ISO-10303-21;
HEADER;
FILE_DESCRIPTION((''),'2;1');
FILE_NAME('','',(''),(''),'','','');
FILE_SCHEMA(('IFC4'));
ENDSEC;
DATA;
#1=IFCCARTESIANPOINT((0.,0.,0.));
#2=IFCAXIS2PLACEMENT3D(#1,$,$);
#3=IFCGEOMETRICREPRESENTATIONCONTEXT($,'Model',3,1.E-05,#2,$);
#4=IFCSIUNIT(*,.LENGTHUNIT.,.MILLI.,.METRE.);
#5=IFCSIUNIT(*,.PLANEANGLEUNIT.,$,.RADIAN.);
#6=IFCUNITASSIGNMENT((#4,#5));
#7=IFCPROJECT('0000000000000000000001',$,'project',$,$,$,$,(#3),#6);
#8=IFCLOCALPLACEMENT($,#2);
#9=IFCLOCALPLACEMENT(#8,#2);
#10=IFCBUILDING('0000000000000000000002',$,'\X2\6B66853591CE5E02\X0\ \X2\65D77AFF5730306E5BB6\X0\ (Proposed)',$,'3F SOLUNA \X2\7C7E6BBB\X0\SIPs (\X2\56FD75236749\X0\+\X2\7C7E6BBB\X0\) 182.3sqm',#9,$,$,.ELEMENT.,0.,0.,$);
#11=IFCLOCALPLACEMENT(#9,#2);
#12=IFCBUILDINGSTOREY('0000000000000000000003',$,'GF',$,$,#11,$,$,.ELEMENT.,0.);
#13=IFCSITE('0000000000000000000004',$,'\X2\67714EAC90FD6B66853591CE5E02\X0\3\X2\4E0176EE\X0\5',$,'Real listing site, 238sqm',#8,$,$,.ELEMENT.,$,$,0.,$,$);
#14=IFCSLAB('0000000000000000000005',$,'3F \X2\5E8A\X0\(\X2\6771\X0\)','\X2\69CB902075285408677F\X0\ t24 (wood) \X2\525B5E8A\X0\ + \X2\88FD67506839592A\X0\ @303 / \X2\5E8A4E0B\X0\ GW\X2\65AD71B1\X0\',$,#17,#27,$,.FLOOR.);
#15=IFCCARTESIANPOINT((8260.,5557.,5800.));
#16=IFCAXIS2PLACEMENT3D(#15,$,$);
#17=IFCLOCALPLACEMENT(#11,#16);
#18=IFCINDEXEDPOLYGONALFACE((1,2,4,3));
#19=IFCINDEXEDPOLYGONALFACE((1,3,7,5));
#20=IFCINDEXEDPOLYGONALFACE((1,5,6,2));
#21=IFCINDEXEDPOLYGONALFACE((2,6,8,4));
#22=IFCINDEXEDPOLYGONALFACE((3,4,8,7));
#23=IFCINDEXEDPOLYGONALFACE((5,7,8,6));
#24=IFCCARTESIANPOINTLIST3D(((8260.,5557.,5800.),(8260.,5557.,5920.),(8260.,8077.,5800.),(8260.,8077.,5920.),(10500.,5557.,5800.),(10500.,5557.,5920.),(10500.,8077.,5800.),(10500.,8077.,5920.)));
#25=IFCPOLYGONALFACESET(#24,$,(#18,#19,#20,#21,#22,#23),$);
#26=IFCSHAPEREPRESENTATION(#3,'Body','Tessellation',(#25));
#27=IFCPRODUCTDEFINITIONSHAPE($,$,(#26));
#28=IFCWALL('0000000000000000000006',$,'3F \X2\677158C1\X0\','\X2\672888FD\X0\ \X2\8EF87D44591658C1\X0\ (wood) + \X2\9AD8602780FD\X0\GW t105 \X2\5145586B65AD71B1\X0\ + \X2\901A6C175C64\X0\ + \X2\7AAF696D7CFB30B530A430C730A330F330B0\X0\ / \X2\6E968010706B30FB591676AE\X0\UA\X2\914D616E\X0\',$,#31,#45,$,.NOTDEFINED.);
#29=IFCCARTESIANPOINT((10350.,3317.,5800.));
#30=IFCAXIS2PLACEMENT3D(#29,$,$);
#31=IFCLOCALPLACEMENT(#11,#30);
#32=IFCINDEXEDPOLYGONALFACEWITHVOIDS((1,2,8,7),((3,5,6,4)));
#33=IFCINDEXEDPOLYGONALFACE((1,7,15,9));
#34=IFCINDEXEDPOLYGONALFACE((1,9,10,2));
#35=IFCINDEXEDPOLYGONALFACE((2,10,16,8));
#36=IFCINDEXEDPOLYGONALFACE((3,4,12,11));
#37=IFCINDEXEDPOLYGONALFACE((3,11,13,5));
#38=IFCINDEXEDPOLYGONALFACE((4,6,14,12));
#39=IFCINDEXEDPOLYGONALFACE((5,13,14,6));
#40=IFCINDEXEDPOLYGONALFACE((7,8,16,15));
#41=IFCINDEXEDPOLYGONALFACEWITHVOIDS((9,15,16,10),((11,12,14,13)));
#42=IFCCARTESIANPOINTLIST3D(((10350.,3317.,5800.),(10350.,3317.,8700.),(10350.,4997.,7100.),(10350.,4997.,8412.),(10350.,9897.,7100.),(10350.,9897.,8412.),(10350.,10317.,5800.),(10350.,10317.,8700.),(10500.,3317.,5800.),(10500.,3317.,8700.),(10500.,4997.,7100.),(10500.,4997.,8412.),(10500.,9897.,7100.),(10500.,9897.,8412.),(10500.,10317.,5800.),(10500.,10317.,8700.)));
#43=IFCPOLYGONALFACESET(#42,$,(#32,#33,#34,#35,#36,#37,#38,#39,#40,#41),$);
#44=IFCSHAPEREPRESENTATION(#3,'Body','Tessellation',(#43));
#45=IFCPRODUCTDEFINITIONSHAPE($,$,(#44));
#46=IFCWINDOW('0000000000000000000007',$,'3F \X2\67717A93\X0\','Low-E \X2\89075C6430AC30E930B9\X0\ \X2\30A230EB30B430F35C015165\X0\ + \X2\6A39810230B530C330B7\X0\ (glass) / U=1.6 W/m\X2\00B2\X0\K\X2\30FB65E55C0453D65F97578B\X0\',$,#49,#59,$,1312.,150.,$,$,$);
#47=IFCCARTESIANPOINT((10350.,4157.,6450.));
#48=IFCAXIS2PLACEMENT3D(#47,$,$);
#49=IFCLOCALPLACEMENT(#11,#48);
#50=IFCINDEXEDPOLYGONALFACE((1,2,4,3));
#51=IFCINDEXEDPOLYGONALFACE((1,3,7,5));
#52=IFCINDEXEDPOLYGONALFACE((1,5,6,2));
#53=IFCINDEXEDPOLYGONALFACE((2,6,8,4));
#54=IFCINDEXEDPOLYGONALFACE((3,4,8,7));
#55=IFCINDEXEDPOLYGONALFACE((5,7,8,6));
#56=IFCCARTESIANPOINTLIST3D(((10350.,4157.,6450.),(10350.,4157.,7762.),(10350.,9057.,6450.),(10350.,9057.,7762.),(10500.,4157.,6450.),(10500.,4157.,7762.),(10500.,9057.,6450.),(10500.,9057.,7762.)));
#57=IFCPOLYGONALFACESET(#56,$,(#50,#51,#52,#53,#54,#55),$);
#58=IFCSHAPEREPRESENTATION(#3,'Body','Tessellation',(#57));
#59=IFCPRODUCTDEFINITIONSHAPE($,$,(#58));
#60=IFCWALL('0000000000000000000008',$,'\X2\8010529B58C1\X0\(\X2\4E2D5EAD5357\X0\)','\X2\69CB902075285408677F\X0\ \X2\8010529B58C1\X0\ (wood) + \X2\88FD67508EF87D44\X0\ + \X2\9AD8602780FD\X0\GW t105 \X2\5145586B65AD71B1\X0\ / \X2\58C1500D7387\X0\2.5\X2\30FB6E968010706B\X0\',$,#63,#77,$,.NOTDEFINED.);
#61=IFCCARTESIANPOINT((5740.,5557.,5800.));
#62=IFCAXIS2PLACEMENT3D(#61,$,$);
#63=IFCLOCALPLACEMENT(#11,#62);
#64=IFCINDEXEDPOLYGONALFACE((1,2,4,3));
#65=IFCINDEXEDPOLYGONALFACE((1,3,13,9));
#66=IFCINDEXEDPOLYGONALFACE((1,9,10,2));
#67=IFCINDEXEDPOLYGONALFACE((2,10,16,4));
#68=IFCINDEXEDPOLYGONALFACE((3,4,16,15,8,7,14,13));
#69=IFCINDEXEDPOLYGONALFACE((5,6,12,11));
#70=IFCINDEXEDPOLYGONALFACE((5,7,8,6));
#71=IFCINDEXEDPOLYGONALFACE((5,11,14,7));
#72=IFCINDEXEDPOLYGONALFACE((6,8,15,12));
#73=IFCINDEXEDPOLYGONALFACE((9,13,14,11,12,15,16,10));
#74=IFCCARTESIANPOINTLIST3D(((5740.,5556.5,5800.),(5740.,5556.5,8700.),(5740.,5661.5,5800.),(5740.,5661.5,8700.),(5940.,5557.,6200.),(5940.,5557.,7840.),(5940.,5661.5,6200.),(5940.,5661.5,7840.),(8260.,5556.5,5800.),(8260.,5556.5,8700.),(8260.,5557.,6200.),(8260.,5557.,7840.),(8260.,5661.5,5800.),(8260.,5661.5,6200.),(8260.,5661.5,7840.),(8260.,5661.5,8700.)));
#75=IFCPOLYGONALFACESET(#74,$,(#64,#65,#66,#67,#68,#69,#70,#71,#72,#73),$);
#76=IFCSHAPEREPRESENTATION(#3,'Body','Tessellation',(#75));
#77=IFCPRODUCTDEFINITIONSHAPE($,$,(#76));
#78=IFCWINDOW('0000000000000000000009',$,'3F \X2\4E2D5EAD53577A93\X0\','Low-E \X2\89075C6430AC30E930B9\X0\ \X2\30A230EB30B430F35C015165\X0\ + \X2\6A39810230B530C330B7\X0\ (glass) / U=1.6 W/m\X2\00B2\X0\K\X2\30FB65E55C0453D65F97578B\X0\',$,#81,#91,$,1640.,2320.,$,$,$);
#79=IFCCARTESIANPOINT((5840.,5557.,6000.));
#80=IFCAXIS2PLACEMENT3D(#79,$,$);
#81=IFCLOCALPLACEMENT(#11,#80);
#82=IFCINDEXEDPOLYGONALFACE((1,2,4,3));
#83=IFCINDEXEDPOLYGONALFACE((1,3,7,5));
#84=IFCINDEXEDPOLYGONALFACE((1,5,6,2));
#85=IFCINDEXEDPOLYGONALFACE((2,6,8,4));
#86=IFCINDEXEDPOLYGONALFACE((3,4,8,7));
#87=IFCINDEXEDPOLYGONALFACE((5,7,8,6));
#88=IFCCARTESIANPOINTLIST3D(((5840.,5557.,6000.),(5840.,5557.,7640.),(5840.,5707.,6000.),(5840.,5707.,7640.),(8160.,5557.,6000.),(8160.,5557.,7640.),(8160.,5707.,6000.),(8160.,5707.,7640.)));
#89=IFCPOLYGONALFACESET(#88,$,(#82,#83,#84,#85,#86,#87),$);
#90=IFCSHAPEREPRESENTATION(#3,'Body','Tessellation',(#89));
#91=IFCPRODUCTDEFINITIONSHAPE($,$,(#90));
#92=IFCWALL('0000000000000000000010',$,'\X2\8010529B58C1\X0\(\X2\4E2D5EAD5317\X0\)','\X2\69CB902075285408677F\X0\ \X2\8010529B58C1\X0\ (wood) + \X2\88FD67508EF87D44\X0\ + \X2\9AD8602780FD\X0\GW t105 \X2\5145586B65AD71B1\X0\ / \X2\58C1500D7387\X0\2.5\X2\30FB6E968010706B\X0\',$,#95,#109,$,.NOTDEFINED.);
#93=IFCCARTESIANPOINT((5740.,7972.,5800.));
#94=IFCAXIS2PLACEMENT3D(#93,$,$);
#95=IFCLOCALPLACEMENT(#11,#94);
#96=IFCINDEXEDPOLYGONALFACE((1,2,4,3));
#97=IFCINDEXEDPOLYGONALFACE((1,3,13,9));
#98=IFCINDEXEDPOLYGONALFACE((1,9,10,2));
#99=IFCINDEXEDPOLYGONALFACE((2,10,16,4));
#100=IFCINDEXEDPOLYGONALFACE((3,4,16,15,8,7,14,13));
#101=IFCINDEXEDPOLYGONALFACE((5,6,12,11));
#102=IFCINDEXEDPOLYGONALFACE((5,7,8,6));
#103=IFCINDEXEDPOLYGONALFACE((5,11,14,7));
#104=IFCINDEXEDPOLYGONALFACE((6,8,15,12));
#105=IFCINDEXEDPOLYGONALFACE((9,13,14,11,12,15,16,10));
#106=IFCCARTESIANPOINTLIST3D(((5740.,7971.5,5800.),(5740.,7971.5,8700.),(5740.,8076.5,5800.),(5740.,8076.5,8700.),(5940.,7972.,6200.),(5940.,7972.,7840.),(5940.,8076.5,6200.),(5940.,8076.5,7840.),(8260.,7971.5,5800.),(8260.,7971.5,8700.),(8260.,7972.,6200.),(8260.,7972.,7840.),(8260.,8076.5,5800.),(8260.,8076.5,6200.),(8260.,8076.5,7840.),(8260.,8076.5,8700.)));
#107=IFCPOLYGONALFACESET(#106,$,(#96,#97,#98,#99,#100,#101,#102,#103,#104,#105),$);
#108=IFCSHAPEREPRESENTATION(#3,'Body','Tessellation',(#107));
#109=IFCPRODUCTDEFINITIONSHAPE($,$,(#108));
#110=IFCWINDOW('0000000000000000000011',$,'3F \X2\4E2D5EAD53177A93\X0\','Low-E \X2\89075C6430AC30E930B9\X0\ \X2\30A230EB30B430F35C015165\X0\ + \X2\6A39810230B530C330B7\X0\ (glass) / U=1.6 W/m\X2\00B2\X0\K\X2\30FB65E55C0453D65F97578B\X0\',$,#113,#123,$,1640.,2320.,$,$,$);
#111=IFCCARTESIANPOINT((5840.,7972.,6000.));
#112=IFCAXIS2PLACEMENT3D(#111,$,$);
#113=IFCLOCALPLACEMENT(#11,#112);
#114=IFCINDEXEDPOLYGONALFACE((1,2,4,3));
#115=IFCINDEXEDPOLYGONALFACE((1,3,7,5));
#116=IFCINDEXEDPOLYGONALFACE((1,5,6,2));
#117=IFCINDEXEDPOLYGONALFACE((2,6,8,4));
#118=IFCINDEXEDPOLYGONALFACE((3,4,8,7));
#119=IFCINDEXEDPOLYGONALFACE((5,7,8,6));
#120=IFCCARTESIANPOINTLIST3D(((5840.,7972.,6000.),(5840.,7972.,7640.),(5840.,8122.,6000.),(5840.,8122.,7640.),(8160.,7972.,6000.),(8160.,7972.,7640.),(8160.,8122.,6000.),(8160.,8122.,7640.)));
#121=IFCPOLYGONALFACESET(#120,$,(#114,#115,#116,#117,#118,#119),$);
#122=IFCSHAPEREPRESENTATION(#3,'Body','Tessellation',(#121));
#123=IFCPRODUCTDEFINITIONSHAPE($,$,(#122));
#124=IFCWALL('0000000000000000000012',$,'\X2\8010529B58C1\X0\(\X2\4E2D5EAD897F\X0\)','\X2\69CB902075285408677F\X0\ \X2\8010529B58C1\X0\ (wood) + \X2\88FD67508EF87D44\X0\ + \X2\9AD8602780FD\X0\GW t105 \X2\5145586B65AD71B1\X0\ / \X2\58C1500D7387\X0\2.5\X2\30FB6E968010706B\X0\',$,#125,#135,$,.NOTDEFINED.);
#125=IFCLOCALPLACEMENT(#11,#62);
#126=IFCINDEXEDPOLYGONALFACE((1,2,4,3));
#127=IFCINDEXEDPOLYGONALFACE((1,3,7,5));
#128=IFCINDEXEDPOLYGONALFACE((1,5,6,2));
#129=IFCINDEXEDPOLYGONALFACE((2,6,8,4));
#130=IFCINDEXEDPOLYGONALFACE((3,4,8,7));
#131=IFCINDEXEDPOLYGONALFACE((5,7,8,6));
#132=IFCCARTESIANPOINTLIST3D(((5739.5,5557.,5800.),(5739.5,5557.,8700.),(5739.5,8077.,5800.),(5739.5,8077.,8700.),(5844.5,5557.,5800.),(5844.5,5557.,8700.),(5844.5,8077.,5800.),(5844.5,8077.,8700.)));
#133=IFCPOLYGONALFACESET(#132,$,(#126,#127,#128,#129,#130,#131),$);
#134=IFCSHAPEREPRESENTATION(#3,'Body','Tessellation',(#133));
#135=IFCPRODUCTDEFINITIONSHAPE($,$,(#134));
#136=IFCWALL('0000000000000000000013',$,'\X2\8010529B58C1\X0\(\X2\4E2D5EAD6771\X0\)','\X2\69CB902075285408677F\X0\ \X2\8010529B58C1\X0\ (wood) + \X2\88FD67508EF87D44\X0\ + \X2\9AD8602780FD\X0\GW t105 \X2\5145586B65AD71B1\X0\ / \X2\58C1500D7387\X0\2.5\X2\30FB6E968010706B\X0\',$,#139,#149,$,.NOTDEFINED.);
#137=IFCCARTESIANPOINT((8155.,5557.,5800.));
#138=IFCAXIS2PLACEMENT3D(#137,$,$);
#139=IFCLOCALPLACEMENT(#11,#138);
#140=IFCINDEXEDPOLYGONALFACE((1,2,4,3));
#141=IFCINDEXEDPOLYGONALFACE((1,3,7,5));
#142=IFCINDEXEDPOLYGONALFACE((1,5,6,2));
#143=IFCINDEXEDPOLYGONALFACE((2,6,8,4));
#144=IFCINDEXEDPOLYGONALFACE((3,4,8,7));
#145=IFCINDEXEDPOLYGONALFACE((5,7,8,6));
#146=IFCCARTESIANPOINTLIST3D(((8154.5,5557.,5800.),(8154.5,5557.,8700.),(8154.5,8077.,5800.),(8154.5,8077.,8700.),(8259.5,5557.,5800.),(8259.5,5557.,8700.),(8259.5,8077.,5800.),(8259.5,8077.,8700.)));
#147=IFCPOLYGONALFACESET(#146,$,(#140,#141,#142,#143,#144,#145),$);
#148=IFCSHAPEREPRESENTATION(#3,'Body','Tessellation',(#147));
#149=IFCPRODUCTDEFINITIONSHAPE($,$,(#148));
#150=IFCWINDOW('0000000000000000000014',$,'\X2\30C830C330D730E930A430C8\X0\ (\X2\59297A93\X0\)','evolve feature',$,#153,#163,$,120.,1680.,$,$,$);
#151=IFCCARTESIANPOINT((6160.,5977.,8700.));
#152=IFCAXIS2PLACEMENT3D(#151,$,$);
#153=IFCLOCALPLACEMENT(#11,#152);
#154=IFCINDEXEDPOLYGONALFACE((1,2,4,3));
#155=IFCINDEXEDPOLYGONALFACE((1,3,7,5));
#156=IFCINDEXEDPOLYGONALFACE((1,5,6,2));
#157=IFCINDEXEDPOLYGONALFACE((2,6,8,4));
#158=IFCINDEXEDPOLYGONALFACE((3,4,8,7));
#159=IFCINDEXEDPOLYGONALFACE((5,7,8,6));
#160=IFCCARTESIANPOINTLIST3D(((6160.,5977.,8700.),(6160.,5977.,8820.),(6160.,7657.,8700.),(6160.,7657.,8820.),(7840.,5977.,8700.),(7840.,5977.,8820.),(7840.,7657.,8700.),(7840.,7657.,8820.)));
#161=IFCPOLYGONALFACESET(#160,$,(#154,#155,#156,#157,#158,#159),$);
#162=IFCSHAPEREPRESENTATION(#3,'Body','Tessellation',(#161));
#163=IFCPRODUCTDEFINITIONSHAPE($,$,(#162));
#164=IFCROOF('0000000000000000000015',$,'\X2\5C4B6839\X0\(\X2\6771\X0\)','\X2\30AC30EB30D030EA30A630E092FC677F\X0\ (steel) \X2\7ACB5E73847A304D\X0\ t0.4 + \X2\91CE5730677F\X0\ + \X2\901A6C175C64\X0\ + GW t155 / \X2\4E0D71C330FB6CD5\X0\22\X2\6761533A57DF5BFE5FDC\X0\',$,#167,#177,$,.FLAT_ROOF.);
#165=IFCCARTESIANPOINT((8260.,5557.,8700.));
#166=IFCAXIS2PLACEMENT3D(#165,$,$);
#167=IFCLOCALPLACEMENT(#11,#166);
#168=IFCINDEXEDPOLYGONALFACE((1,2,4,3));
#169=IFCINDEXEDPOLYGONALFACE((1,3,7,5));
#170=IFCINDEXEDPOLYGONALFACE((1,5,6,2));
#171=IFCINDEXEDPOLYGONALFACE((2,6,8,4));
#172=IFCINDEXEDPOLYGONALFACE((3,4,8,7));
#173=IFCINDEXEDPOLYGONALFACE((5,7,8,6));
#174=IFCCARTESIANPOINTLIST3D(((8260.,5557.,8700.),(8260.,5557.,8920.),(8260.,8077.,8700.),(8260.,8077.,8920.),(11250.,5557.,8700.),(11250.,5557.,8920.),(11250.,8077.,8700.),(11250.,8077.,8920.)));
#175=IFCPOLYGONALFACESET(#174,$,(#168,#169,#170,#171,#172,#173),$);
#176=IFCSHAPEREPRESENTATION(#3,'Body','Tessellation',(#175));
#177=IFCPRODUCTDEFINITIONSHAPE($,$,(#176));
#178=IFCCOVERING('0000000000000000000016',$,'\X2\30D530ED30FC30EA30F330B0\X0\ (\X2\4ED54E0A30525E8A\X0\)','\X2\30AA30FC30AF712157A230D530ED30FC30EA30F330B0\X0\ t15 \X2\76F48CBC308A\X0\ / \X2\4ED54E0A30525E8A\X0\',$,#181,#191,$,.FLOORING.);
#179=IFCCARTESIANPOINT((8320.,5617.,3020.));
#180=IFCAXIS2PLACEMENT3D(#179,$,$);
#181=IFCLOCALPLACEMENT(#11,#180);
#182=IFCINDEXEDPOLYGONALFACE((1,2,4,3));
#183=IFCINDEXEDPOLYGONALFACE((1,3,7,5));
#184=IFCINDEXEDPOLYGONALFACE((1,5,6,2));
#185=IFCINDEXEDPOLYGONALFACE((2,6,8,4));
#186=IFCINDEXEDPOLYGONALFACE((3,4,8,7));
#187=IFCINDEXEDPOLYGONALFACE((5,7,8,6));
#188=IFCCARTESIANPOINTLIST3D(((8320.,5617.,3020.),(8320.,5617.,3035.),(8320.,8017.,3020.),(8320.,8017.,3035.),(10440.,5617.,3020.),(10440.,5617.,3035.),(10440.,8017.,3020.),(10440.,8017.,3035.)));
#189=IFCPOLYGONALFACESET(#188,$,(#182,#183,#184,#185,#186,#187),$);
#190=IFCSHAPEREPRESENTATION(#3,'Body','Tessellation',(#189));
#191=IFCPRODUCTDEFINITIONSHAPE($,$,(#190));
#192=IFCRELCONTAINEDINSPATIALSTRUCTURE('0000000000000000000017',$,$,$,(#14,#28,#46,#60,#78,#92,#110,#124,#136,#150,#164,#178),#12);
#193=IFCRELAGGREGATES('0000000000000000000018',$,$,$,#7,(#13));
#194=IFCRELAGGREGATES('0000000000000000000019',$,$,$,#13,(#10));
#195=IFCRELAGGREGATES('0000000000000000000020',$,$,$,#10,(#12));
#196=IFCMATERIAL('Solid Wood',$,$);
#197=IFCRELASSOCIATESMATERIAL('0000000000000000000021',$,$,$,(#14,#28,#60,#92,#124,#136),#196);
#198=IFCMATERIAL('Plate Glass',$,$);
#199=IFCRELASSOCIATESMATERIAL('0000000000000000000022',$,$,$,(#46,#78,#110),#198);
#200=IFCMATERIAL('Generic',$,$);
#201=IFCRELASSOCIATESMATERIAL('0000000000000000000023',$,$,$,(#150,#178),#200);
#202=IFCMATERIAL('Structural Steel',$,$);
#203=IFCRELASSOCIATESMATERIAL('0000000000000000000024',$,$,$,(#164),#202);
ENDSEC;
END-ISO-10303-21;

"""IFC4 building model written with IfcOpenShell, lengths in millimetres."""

from ifc_helpers import new_model, si_unit, frame, frame_2d, origin, place, context, project, spatial, rectangle, extrude, material, element, fill, save


model = new_model("IFC4")

# Units and contexts
model_context = context("Model", 3, precision=1e-05, world=origin())
ifc_project = project(units=[si_unit("LENGTHUNIT", "METRE", prefix="MILLI"), si_unit("PLANEANGLEUNIT", "RADIAN")], contexts=[model_context])

# Site, building, storey
site_placement = place(None, origin())
site = spatial("IfcSite", under=ifc_project, at=site_placement, Name="東京都武蔵野市3丁目5", ObjectType="Real listing site, 238sqm", CompositionType="ELEMENT", RefElevation=0.0)
building_placement = place(site_placement, origin())
building = spatial("IfcBuilding", under=site, at=building_placement, Name="武蔵野市 旗竿地の家 (Proposed)", ObjectType="3F SOLUNA 籾殻SIPs (国産杉+籾殻) 182.3sqm", CompositionType="ELEMENT", ElevationOfRefHeight=0.0, ElevationOfTerrain=0.0)
storey_placement = place(building_placement, origin())
storey = spatial("IfcBuildingStorey", under=building, at=storey_placement, Name="GF", CompositionType="ELEMENT", Elevation=0.0)

# Slab
ifc_material_1 = material(Name="Solid Wood")
slab_placement = place(storey_placement, frame((8260.0, 5557.0, 5800.0)))
element("IfcSlab", 1, at=slab_placement, inside=storey, material=ifc_material_1, Name="3F 床(東)", Description="構造用合板 t24 (wood) 剛床 + 製材根太 @303 / 床下 GW断熱", PredefinedType="FLOOR", context=model_context, shape_type="SweptSolid", body=[
    extrude(rectangle(XDim=2240.0, YDim=2520.0, at=frame_2d((1120.0, 1260.0))), frame((8260.0, 5557.0, 5800.0)), (0.0, 0.0, 1.0), 120.0),
])

# Walls, openings, windows
wall_1_placement = place(storey_placement, frame((10350.0, 3317.0, 5800.0)))
wall_1 = element("IfcWall", 2, at=wall_1_placement, inside=storey, material=ifc_material_1, Name="3F 東壁", Description="木製 軸組外壁 (wood) + 高性能GW t105 充填断熱 + 通気層 + 窯業系サイディング / 準耐火・外皮UA配慮", PredefinedType="NOTDEFINED", context=model_context, shape_type="SweptSolid", body=[
    extrude(rectangle(XDim=150.0, YDim=7000.0, at=frame_2d((75.0, 3500.0))), frame((10350.0, 3317.0, 5800.0)), (0.0, 0.0, 1.0), 2900.0),
])
opening_1_placement = place(storey_placement, frame((10350.0, 4157.0, 6450.0)))
opening_1 = element("IfcOpeningElement", 3, at=opening_1_placement, cuts=wall_1, PredefinedType="NOTDEFINED", context=model_context, shape_type="SweptSolid", body=[
    extrude(rectangle(XDim=150.0, YDim=4900.0, at=frame_2d((75.0, 2450.0))), frame((10350.0, 4157.0, 6450.0)), (0.0, 0.0, 1.0), 1312.0),
])
ifc_material_2 = material(Name="Plate Glass")
window_1_placement = place(storey_placement, frame((10350.0, 4157.0, 6450.0)))
window_1 = element("IfcWindow", 4, at=window_1_placement, inside=storey, material=ifc_material_2, Name="3F 東窓", Description="Low-E 複層ガラス アルゴン封入 + 樹脂サッシ (glass) / U=1.6 W/m²K・日射取得型", OverallHeight=1312.0, OverallWidth=150.0, context=model_context, shape_type="SweptSolid", body=[
    extrude(rectangle(XDim=150.0, YDim=4900.0, at=frame_2d((75.0, 2450.0))), frame((10350.0, 4157.0, 6450.0)), (0.0, 0.0, 1.0), 1312.0),
])
fill(opening_1, window_1)
wall_2_placement = place(storey_placement, frame((5740.0, 5557.0, 5800.0)))
wall_2 = element("IfcWall", 5, at=wall_2_placement, inside=storey, material=ifc_material_1, Name="耐力壁(中庭南)", Description="構造用合板 耐力壁 (wood) + 製材軸組 + 高性能GW t105 充填断熱 / 壁倍率2.5・準耐火", PredefinedType="NOTDEFINED", context=model_context, shape_type="SweptSolid", body=[
    extrude(rectangle(XDim=2520.0, YDim=105.0, at=frame_2d((1260.0, 52.0))), frame((5740.0, 5557.0, 5800.0)), (0.0, 0.0, 1.0), 2900.0),
])
opening_2_placement = place(storey_placement, frame((5840.0, 5557.0, 6000.0)))
opening_2 = element("IfcOpeningElement", 6, at=opening_2_placement, cuts=wall_2, PredefinedType="NOTDEFINED", context=model_context, shape_type="SweptSolid", body=[
    extrude(rectangle(XDim=2320.0, YDim=150.0, at=frame_2d((1160.0, 75.0))), frame((5840.0, 5557.0, 6000.0)), (0.0, 0.0, 1.0), 1640.0),
])
window_2_placement = place(storey_placement, frame((5840.0, 5557.0, 6000.0)))
window_2 = element("IfcWindow", 7, at=window_2_placement, inside=storey, material=ifc_material_2, Name="3F 中庭南窓", Description="Low-E 複層ガラス アルゴン封入 + 樹脂サッシ (glass) / U=1.6 W/m²K・日射取得型", OverallHeight=1640.0, OverallWidth=2320.0, context=model_context, shape_type="SweptSolid", body=[
    extrude(rectangle(XDim=2320.0, YDim=150.0, at=frame_2d((1160.0, 75.0))), frame((5840.0, 5557.0, 6000.0)), (0.0, 0.0, 1.0), 1640.0),
])
fill(opening_2, window_2)
wall_3_placement = place(storey_placement, frame((5740.0, 7972.0, 5800.0)))
wall_3 = element("IfcWall", 8, at=wall_3_placement, inside=storey, material=ifc_material_1, Name="耐力壁(中庭北)", Description="構造用合板 耐力壁 (wood) + 製材軸組 + 高性能GW t105 充填断熱 / 壁倍率2.5・準耐火", PredefinedType="NOTDEFINED", context=model_context, shape_type="SweptSolid", body=[
    extrude(rectangle(XDim=2520.0, YDim=105.0, at=frame_2d((1260.0, 52.0))), frame((5740.0, 7972.0, 5800.0)), (0.0, 0.0, 1.0), 2900.0),
])
opening_3_placement = place(storey_placement, frame((5840.0, 7972.0, 6000.0)))
opening_3 = element("IfcOpeningElement", 9, at=opening_3_placement, cuts=wall_3, PredefinedType="NOTDEFINED", context=model_context, shape_type="SweptSolid", body=[
    extrude(rectangle(XDim=2320.0, YDim=150.0, at=frame_2d((1160.0, 75.0))), frame((5840.0, 7972.0, 6000.0)), (0.0, 0.0, 1.0), 1640.0),
])
window_3_placement = place(storey_placement, frame((5840.0, 7972.0, 6000.0)))
window_3 = element("IfcWindow", 10, at=window_3_placement, inside=storey, material=ifc_material_2, Name="3F 中庭北窓", Description="Low-E 複層ガラス アルゴン封入 + 樹脂サッシ (glass) / U=1.6 W/m²K・日射取得型", OverallHeight=1640.0, OverallWidth=2320.0, context=model_context, shape_type="SweptSolid", body=[
    extrude(rectangle(XDim=2320.0, YDim=150.0, at=frame_2d((1160.0, 75.0))), frame((5840.0, 7972.0, 6000.0)), (0.0, 0.0, 1.0), 1640.0),
])
fill(opening_3, window_3)

# Walls
wall_4_placement = place(storey_placement, frame((5740.0, 5557.0, 5800.0)))
element("IfcWall", 11, at=wall_4_placement, inside=storey, material=ifc_material_1, Name="耐力壁(中庭西)", Description="構造用合板 耐力壁 (wood) + 製材軸組 + 高性能GW t105 充填断熱 / 壁倍率2.5・準耐火", PredefinedType="NOTDEFINED", context=model_context, shape_type="SweptSolid", body=[
    extrude(rectangle(XDim=105.0, YDim=2520.0, at=frame_2d((52.0, 1260.0))), frame((5740.0, 5557.0, 5800.0)), (0.0, 0.0, 1.0), 2900.0),
])
wall_5_placement = place(storey_placement, frame((8155.0, 5557.0, 5800.0)))
element("IfcWall", 12, at=wall_5_placement, inside=storey, material=ifc_material_1, Name="耐力壁(中庭東)", Description="構造用合板 耐力壁 (wood) + 製材軸組 + 高性能GW t105 充填断熱 / 壁倍率2.5・準耐火", PredefinedType="NOTDEFINED", context=model_context, shape_type="SweptSolid", body=[
    extrude(rectangle(XDim=105.0, YDim=2520.0, at=frame_2d((52.0, 1260.0))), frame((8155.0, 5557.0, 5800.0)), (0.0, 0.0, 1.0), 2900.0),
])

# Window
ifc_material_3 = material(Name="Generic")
window_4_placement = place(storey_placement, frame((6160.0, 5977.0, 8700.0)))
element("IfcWindow", 13, at=window_4_placement, inside=storey, material=ifc_material_3, Name="トップライト (天窓)", Description="evolve feature", OverallHeight=120.0, OverallWidth=1680.0, context=model_context, shape_type="SweptSolid", body=[
    extrude(rectangle(XDim=1680.0, YDim=1680.0, at=frame_2d((840.0, 840.0))), frame((6160.0, 5977.0, 8700.0)), (0.0, 0.0, 1.0), 120.0),
])

# Roof
ifc_material_4 = material(Name="Structural Steel")
for number, where, name in (
    (14, (8260.0, 5557.0, 8700.0), "屋根(東)"),
):
    element("IfcRoof", number, at=place(storey_placement, frame(where)), inside=storey, material=ifc_material_4, Name=name, Description="ガルバリウム鋼板 (steel) 立平葺き t0.4 + 野地板 + 通気層 + GW t155 / 不燃・法22条区域対応", PredefinedType="FLAT_ROOF", context=model_context, shape_type="SweptSolid", body=[
        extrude(rectangle(XDim=2990.0, YDim=2520.0, at=frame_2d((1495.0, 1260.0))), frame((8260.0, 5557.0, 8700.0)), (0.0, 0.0, 1.0), 220.0),
    ])

# Covering
covering_1_placement = place(storey_placement, frame((8320.0, 5617.0, 3020.0)))
element("IfcCovering", 15, at=covering_1_placement, inside=storey, material=ifc_material_3, Name="フローリング (仕上げ床)", Description="オーク無垢フローリング t15 直貼り / 仕上げ床", PredefinedType="FLOORING", context=model_context, shape_type="SweptSolid", body=[
    extrude(rectangle(XDim=2120.0, YDim=2400.0, at=frame_2d((1060.0, 1200.0))), frame((8320.0, 5617.0, 3020.0)), (0.0, 0.0, 1.0), 15.0),
])

save(model, "model.ifc")
